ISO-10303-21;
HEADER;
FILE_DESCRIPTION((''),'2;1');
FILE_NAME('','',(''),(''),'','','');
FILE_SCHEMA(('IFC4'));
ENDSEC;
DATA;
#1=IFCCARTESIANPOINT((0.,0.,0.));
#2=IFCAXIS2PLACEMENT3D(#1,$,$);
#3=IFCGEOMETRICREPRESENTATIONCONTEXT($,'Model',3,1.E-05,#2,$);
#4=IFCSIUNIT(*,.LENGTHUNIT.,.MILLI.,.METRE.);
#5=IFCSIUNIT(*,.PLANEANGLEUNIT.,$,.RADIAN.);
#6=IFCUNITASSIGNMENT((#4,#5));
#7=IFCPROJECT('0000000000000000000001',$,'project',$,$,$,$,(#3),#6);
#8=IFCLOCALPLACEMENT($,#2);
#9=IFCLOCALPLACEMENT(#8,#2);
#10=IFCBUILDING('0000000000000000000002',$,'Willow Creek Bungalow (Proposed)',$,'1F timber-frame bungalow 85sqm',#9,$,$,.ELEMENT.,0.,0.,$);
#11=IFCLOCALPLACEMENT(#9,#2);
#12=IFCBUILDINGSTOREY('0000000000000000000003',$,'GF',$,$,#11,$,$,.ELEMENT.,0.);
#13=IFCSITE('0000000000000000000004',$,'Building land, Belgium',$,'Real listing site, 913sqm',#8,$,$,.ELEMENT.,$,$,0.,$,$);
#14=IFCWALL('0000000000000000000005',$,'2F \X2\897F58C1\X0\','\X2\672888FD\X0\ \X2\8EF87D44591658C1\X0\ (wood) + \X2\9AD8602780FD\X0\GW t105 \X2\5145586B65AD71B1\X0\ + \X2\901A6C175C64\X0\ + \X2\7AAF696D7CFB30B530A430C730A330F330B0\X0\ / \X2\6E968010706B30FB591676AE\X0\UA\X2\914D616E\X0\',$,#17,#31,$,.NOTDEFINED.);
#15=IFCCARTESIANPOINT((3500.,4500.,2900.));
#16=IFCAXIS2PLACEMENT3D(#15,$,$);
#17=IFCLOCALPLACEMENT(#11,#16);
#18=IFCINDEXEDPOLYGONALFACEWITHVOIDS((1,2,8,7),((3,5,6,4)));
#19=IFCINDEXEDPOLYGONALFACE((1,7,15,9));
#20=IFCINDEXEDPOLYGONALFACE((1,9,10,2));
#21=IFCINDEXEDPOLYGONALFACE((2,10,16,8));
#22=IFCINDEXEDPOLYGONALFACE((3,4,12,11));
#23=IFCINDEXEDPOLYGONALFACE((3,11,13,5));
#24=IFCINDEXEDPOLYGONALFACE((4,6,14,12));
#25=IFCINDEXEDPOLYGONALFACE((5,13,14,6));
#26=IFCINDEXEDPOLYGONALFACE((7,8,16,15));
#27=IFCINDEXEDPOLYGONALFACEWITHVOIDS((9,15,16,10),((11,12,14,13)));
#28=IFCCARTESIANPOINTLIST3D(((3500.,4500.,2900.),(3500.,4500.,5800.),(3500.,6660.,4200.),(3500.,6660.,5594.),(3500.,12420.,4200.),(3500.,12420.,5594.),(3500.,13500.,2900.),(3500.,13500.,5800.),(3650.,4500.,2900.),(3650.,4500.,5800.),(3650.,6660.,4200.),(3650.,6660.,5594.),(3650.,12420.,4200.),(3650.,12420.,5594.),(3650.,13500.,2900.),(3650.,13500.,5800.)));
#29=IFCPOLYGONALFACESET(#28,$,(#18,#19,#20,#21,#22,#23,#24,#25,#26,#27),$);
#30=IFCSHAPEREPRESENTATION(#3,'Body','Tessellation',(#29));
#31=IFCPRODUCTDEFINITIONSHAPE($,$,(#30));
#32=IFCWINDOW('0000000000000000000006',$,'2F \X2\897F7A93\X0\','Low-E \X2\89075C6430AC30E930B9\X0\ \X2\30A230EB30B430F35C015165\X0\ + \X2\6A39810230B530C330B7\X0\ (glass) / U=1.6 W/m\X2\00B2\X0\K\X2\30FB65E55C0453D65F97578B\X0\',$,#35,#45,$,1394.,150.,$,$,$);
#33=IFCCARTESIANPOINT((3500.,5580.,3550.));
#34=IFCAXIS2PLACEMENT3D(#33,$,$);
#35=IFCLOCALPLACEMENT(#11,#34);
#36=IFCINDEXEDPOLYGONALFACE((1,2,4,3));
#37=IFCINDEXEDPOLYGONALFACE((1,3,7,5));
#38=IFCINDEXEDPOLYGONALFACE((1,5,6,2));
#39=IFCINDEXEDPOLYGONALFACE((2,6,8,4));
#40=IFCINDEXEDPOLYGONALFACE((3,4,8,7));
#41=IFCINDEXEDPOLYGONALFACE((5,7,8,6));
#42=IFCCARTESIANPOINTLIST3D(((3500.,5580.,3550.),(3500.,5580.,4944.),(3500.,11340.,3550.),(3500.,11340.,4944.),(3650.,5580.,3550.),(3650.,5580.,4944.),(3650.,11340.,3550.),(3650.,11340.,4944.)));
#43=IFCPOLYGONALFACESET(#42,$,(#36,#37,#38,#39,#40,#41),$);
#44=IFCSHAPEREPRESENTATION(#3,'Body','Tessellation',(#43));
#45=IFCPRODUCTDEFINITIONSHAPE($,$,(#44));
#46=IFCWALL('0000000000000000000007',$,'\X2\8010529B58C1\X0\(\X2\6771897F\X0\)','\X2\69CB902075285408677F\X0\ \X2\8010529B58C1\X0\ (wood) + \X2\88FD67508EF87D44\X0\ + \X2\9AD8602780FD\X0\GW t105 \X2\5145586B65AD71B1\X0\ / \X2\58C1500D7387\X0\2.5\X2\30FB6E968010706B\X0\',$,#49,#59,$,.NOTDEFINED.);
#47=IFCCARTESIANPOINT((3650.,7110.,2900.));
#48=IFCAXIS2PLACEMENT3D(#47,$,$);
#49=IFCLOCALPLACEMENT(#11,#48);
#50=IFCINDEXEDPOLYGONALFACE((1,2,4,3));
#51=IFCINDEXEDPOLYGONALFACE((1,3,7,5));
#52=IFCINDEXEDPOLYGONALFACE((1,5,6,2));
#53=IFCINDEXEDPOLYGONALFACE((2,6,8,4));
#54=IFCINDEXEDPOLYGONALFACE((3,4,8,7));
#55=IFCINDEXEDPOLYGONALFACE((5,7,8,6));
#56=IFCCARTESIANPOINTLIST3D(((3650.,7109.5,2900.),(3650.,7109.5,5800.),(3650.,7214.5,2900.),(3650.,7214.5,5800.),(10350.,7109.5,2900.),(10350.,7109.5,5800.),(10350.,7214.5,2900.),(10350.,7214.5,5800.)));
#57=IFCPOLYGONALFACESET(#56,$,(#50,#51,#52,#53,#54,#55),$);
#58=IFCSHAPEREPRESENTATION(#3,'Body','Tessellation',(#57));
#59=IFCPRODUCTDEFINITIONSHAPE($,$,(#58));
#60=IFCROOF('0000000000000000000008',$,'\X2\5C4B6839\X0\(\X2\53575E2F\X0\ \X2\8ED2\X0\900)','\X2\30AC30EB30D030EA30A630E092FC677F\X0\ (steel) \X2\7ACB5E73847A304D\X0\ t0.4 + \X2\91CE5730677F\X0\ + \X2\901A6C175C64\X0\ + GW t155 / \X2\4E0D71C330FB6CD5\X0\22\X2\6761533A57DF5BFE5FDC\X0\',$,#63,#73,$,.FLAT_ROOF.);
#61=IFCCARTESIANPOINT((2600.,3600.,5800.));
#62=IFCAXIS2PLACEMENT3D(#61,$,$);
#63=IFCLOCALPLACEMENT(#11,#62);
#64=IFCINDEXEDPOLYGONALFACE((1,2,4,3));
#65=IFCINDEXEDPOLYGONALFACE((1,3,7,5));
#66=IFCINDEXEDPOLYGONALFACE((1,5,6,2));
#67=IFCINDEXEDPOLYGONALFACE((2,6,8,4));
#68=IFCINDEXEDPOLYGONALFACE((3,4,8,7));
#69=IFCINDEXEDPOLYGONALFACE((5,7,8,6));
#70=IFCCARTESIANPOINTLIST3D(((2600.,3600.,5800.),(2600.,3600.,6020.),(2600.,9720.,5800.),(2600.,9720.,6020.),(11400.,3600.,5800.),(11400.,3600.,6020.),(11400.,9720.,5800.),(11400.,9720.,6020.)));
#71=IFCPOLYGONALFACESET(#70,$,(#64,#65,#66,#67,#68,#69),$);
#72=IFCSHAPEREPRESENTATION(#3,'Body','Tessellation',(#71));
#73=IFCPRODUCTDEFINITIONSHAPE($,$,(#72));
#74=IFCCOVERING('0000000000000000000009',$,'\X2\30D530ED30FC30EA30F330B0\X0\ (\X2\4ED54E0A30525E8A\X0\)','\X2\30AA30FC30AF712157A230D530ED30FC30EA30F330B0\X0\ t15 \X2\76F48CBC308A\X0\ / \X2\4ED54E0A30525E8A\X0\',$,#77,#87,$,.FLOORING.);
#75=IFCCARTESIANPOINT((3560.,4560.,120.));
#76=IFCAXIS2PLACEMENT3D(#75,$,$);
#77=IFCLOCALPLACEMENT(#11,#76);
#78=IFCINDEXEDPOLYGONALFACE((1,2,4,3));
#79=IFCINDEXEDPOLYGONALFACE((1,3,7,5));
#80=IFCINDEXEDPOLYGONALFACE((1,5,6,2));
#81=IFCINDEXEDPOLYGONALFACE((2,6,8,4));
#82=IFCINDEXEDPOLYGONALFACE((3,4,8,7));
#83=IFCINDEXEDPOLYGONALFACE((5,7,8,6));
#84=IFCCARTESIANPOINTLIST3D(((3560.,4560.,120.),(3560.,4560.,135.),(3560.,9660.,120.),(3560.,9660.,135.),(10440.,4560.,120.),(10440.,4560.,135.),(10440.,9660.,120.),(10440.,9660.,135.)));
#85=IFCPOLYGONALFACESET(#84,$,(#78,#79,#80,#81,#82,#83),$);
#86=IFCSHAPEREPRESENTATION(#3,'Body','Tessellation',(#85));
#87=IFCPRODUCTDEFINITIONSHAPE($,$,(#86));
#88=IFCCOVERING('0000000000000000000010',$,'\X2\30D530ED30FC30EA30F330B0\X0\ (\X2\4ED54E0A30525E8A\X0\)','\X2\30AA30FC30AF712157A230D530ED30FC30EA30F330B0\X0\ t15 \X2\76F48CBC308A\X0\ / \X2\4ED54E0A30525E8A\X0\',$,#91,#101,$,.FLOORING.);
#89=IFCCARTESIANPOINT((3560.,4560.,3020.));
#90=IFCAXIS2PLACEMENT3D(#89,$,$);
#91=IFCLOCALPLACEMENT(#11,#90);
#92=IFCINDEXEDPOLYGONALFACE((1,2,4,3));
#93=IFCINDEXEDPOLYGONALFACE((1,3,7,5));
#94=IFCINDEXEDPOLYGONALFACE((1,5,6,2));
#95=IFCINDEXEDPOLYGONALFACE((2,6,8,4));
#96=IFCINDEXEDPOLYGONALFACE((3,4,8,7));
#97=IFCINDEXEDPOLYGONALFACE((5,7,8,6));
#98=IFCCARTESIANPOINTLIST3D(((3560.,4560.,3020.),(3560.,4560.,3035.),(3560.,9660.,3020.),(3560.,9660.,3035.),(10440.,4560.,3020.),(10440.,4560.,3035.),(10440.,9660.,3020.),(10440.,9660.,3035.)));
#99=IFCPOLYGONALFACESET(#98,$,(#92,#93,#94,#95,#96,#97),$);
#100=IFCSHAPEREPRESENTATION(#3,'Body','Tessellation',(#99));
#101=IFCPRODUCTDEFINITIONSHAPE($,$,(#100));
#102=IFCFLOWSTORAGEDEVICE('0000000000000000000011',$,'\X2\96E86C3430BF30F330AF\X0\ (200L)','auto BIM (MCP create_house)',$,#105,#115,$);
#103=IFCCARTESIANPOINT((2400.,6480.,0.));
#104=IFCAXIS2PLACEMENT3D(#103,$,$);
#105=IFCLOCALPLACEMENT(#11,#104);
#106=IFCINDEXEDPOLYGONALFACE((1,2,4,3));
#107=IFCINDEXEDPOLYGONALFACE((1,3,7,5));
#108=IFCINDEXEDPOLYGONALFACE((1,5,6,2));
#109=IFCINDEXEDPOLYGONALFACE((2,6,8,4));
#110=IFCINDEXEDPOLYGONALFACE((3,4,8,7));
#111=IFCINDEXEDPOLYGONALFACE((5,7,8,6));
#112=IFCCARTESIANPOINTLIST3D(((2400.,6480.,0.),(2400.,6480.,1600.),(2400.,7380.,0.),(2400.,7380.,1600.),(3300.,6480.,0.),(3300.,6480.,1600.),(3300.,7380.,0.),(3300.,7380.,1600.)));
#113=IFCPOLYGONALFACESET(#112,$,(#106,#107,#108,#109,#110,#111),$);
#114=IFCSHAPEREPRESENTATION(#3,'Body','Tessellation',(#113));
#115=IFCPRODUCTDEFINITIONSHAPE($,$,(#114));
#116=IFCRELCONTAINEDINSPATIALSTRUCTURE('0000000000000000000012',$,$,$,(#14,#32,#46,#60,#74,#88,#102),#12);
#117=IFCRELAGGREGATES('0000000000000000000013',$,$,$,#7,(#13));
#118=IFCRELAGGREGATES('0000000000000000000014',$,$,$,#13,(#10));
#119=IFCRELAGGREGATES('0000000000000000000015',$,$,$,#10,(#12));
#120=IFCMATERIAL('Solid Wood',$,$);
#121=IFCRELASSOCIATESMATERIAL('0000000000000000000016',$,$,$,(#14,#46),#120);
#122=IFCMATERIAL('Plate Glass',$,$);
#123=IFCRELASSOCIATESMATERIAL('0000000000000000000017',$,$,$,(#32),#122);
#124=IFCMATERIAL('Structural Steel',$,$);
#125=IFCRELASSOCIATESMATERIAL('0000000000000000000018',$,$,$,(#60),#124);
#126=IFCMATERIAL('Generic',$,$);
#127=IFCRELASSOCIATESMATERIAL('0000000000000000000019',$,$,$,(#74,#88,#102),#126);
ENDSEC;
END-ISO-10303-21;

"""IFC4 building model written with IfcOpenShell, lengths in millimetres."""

from ifc_helpers import new_model, si_unit, frame, frame_2d, origin, place, context, project, spatial, rectangle, extrude, material, element, fill, save


model = new_model("IFC4")

# Units and contexts
model_context = context("Model", 3, precision=1e-05, world=origin())
ifc_project = project(units=[si_unit("LENGTHUNIT", "METRE", prefix="MILLI"), si_unit("PLANEANGLEUNIT", "RADIAN")], contexts=[model_context])

# Site, building, storey
site_placement = place(None, origin())
site = spatial("IfcSite", under=ifc_project, at=site_placement, Name="Building land, Belgium", ObjectType="Real listing site, 913sqm", CompositionType="ELEMENT", RefElevation=0.0)
building_placement = place(site_placement, origin())
building = spatial("IfcBuilding", under=site, at=building_placement, Name="Willow Creek Bungalow (Proposed)", ObjectType="1F timber-frame bungalow 85sqm", CompositionType="ELEMENT", ElevationOfRefHeight=0.0, ElevationOfTerrain=0.0)
storey_placement = place(building_placement, origin())
storey = spatial("IfcBuildingStorey", under=building, at=storey_placement, Name="GF", CompositionType="ELEMENT", Elevation=0.0)

# Shared definitions
ifc_material_1 = material(Name="Solid Wood")
ifc_material_2 = material(Name="Generic")

# Shared definitions
ifc_material_3 = material(Name="Plate Glass")

# Wall, opening, window
wall_1_placement = place(storey_placement, frame((3500.0, 4500.0, 2900.0)))
wall_1 = element("IfcWall", 1, at=wall_1_placement, inside=storey, material=ifc_material_1, Name="2F 西壁", Description="木製 軸組外壁 (wood) + 高性能GW t105 充填断熱 + 通気層 + 窯業系サイディング / 準耐火・外皮UA配慮", PredefinedType="NOTDEFINED", context=model_context, shape_type="SweptSolid", body=[
    extrude(rectangle(XDim=150.0, YDim=9000.0, at=frame_2d((75.0, 4500.0))), frame((3500.0, 4500.0, 2900.0)), (0.0, 0.0, 1.0), 2900.0),
])
opening_1_placement = place(storey_placement, frame((3500.0, 5580.0, 3550.0)))
opening_1 = element("IfcOpeningElement", 2, at=opening_1_placement, cuts=wall_1, PredefinedType="NOTDEFINED", context=model_context, shape_type="SweptSolid", body=[
    extrude(rectangle(XDim=150.0, YDim=5760.0, at=frame_2d((75.0, 2880.0))), frame((3500.0, 5580.0, 3550.0)), (0.0, 0.0, 1.0), 1394.0),
])
window_1_placement = place(storey_placement, frame((3500.0, 5580.0, 3550.0)))
window_1 = element("IfcWindow", 3, at=window_1_placement, inside=storey, material=ifc_material_3, Name="2F 西窓", Description="Low-E 複層ガラス アルゴン封入 + 樹脂サッシ (glass) / U=1.6 W/m²K・日射取得型", OverallHeight=1394.0, OverallWidth=150.0, context=model_context, shape_type="SweptSolid", body=[
    extrude(rectangle(XDim=150.0, YDim=5760.0, at=frame_2d((75.0, 2880.0))), frame((3500.0, 5580.0, 3550.0)), (0.0, 0.0, 1.0), 1394.0),
])
fill(opening_1, window_1)

# Wall
wall_2_placement = place(storey_placement, frame((3650.0, 7110.0, 2900.0)))
element("IfcWall", 4, at=wall_2_placement, inside=storey, material=ifc_material_1, Name="耐力壁(東西)", Description="構造用合板 耐力壁 (wood) + 製材軸組 + 高性能GW t105 充填断熱 / 壁倍率2.5・準耐火", PredefinedType="NOTDEFINED", context=model_context, shape_type="SweptSolid", body=[
    extrude(rectangle(XDim=6700.0, YDim=105.0, at=frame_2d((3350.0, 52.0))), frame((3650.0, 7110.0, 2900.0)), (0.0, 0.0, 1.0), 2900.0),
])

# Roof
ifc_material_4 = material(Name="Structural Steel")
for number, where, name in (
    (5, (2600.0, 3600.0, 5800.0), "屋根(南帯 軒900)"),
):
    element("IfcRoof", number, at=place(storey_placement, frame(where)), inside=storey, material=ifc_material_4, Name=name, Description="ガルバリウム鋼板 (steel) 立平葺き t0.4 + 野地板 + 通気層 + GW t155 / 不燃・法22条区域対応", PredefinedType="FLAT_ROOF", context=model_context, shape_type="SweptSolid", body=[
        extrude(rectangle(XDim=8800.0, YDim=6120.0, at=frame_2d((4400.0, 3060.0))), frame((2600.0, 3600.0, 5800.0)), (0.0, 0.0, 1.0), 220.0),
    ])

# Coverings
covering_1_placement = place(storey_placement, frame((3560.0, 4560.0, 120.0)))
element("IfcCovering", 6, at=covering_1_placement, inside=storey, material=ifc_material_2, Name="フローリング (仕上げ床)", Description="オーク無垢フローリング t15 直貼り / 仕上げ床", PredefinedType="FLOORING", context=model_context, shape_type="SweptSolid", body=[
    extrude(rectangle(XDim=6880.0, YDim=5100.0, at=frame_2d((3440.0, 2550.0))), frame((3560.0, 4560.0, 120.0)), (0.0, 0.0, 1.0), 15.0),
])
covering_2_placement = place(storey_placement, frame((3560.0, 4560.0, 3020.0)))
element("IfcCovering", 7, at=covering_2_placement, inside=storey, material=ifc_material_2, Name="フローリング (仕上げ床)", Description="オーク無垢フローリング t15 直貼り / 仕上げ床", PredefinedType="FLOORING", context=model_context, shape_type="SweptSolid", body=[
    extrude(rectangle(XDim=6880.0, YDim=5100.0, at=frame_2d((3440.0, 2550.0))), frame((3560.0, 4560.0, 3020.0)), (0.0, 0.0, 1.0), 15.0),
])

# Flow storage device
flow_storage_device_placement = place(storey_placement, frame((2400.0, 6480.0, 0.0)))
element("IfcFlowStorageDevice", 8, at=flow_storage_device_placement, inside=storey, material=ifc_material_2, Name="雨水タンク (200L)", Description="auto BIM (MCP create_house)", context=model_context, shape_type="SweptSolid", body=[
    extrude(rectangle(XDim=900.0, YDim=900.0, at=frame_2d((450.0, 450.0))), frame((2400.0, 6480.0, 0.0)), (0.0, 0.0, 1.0), 1600.0),
])

save(model, "model.ifc")
